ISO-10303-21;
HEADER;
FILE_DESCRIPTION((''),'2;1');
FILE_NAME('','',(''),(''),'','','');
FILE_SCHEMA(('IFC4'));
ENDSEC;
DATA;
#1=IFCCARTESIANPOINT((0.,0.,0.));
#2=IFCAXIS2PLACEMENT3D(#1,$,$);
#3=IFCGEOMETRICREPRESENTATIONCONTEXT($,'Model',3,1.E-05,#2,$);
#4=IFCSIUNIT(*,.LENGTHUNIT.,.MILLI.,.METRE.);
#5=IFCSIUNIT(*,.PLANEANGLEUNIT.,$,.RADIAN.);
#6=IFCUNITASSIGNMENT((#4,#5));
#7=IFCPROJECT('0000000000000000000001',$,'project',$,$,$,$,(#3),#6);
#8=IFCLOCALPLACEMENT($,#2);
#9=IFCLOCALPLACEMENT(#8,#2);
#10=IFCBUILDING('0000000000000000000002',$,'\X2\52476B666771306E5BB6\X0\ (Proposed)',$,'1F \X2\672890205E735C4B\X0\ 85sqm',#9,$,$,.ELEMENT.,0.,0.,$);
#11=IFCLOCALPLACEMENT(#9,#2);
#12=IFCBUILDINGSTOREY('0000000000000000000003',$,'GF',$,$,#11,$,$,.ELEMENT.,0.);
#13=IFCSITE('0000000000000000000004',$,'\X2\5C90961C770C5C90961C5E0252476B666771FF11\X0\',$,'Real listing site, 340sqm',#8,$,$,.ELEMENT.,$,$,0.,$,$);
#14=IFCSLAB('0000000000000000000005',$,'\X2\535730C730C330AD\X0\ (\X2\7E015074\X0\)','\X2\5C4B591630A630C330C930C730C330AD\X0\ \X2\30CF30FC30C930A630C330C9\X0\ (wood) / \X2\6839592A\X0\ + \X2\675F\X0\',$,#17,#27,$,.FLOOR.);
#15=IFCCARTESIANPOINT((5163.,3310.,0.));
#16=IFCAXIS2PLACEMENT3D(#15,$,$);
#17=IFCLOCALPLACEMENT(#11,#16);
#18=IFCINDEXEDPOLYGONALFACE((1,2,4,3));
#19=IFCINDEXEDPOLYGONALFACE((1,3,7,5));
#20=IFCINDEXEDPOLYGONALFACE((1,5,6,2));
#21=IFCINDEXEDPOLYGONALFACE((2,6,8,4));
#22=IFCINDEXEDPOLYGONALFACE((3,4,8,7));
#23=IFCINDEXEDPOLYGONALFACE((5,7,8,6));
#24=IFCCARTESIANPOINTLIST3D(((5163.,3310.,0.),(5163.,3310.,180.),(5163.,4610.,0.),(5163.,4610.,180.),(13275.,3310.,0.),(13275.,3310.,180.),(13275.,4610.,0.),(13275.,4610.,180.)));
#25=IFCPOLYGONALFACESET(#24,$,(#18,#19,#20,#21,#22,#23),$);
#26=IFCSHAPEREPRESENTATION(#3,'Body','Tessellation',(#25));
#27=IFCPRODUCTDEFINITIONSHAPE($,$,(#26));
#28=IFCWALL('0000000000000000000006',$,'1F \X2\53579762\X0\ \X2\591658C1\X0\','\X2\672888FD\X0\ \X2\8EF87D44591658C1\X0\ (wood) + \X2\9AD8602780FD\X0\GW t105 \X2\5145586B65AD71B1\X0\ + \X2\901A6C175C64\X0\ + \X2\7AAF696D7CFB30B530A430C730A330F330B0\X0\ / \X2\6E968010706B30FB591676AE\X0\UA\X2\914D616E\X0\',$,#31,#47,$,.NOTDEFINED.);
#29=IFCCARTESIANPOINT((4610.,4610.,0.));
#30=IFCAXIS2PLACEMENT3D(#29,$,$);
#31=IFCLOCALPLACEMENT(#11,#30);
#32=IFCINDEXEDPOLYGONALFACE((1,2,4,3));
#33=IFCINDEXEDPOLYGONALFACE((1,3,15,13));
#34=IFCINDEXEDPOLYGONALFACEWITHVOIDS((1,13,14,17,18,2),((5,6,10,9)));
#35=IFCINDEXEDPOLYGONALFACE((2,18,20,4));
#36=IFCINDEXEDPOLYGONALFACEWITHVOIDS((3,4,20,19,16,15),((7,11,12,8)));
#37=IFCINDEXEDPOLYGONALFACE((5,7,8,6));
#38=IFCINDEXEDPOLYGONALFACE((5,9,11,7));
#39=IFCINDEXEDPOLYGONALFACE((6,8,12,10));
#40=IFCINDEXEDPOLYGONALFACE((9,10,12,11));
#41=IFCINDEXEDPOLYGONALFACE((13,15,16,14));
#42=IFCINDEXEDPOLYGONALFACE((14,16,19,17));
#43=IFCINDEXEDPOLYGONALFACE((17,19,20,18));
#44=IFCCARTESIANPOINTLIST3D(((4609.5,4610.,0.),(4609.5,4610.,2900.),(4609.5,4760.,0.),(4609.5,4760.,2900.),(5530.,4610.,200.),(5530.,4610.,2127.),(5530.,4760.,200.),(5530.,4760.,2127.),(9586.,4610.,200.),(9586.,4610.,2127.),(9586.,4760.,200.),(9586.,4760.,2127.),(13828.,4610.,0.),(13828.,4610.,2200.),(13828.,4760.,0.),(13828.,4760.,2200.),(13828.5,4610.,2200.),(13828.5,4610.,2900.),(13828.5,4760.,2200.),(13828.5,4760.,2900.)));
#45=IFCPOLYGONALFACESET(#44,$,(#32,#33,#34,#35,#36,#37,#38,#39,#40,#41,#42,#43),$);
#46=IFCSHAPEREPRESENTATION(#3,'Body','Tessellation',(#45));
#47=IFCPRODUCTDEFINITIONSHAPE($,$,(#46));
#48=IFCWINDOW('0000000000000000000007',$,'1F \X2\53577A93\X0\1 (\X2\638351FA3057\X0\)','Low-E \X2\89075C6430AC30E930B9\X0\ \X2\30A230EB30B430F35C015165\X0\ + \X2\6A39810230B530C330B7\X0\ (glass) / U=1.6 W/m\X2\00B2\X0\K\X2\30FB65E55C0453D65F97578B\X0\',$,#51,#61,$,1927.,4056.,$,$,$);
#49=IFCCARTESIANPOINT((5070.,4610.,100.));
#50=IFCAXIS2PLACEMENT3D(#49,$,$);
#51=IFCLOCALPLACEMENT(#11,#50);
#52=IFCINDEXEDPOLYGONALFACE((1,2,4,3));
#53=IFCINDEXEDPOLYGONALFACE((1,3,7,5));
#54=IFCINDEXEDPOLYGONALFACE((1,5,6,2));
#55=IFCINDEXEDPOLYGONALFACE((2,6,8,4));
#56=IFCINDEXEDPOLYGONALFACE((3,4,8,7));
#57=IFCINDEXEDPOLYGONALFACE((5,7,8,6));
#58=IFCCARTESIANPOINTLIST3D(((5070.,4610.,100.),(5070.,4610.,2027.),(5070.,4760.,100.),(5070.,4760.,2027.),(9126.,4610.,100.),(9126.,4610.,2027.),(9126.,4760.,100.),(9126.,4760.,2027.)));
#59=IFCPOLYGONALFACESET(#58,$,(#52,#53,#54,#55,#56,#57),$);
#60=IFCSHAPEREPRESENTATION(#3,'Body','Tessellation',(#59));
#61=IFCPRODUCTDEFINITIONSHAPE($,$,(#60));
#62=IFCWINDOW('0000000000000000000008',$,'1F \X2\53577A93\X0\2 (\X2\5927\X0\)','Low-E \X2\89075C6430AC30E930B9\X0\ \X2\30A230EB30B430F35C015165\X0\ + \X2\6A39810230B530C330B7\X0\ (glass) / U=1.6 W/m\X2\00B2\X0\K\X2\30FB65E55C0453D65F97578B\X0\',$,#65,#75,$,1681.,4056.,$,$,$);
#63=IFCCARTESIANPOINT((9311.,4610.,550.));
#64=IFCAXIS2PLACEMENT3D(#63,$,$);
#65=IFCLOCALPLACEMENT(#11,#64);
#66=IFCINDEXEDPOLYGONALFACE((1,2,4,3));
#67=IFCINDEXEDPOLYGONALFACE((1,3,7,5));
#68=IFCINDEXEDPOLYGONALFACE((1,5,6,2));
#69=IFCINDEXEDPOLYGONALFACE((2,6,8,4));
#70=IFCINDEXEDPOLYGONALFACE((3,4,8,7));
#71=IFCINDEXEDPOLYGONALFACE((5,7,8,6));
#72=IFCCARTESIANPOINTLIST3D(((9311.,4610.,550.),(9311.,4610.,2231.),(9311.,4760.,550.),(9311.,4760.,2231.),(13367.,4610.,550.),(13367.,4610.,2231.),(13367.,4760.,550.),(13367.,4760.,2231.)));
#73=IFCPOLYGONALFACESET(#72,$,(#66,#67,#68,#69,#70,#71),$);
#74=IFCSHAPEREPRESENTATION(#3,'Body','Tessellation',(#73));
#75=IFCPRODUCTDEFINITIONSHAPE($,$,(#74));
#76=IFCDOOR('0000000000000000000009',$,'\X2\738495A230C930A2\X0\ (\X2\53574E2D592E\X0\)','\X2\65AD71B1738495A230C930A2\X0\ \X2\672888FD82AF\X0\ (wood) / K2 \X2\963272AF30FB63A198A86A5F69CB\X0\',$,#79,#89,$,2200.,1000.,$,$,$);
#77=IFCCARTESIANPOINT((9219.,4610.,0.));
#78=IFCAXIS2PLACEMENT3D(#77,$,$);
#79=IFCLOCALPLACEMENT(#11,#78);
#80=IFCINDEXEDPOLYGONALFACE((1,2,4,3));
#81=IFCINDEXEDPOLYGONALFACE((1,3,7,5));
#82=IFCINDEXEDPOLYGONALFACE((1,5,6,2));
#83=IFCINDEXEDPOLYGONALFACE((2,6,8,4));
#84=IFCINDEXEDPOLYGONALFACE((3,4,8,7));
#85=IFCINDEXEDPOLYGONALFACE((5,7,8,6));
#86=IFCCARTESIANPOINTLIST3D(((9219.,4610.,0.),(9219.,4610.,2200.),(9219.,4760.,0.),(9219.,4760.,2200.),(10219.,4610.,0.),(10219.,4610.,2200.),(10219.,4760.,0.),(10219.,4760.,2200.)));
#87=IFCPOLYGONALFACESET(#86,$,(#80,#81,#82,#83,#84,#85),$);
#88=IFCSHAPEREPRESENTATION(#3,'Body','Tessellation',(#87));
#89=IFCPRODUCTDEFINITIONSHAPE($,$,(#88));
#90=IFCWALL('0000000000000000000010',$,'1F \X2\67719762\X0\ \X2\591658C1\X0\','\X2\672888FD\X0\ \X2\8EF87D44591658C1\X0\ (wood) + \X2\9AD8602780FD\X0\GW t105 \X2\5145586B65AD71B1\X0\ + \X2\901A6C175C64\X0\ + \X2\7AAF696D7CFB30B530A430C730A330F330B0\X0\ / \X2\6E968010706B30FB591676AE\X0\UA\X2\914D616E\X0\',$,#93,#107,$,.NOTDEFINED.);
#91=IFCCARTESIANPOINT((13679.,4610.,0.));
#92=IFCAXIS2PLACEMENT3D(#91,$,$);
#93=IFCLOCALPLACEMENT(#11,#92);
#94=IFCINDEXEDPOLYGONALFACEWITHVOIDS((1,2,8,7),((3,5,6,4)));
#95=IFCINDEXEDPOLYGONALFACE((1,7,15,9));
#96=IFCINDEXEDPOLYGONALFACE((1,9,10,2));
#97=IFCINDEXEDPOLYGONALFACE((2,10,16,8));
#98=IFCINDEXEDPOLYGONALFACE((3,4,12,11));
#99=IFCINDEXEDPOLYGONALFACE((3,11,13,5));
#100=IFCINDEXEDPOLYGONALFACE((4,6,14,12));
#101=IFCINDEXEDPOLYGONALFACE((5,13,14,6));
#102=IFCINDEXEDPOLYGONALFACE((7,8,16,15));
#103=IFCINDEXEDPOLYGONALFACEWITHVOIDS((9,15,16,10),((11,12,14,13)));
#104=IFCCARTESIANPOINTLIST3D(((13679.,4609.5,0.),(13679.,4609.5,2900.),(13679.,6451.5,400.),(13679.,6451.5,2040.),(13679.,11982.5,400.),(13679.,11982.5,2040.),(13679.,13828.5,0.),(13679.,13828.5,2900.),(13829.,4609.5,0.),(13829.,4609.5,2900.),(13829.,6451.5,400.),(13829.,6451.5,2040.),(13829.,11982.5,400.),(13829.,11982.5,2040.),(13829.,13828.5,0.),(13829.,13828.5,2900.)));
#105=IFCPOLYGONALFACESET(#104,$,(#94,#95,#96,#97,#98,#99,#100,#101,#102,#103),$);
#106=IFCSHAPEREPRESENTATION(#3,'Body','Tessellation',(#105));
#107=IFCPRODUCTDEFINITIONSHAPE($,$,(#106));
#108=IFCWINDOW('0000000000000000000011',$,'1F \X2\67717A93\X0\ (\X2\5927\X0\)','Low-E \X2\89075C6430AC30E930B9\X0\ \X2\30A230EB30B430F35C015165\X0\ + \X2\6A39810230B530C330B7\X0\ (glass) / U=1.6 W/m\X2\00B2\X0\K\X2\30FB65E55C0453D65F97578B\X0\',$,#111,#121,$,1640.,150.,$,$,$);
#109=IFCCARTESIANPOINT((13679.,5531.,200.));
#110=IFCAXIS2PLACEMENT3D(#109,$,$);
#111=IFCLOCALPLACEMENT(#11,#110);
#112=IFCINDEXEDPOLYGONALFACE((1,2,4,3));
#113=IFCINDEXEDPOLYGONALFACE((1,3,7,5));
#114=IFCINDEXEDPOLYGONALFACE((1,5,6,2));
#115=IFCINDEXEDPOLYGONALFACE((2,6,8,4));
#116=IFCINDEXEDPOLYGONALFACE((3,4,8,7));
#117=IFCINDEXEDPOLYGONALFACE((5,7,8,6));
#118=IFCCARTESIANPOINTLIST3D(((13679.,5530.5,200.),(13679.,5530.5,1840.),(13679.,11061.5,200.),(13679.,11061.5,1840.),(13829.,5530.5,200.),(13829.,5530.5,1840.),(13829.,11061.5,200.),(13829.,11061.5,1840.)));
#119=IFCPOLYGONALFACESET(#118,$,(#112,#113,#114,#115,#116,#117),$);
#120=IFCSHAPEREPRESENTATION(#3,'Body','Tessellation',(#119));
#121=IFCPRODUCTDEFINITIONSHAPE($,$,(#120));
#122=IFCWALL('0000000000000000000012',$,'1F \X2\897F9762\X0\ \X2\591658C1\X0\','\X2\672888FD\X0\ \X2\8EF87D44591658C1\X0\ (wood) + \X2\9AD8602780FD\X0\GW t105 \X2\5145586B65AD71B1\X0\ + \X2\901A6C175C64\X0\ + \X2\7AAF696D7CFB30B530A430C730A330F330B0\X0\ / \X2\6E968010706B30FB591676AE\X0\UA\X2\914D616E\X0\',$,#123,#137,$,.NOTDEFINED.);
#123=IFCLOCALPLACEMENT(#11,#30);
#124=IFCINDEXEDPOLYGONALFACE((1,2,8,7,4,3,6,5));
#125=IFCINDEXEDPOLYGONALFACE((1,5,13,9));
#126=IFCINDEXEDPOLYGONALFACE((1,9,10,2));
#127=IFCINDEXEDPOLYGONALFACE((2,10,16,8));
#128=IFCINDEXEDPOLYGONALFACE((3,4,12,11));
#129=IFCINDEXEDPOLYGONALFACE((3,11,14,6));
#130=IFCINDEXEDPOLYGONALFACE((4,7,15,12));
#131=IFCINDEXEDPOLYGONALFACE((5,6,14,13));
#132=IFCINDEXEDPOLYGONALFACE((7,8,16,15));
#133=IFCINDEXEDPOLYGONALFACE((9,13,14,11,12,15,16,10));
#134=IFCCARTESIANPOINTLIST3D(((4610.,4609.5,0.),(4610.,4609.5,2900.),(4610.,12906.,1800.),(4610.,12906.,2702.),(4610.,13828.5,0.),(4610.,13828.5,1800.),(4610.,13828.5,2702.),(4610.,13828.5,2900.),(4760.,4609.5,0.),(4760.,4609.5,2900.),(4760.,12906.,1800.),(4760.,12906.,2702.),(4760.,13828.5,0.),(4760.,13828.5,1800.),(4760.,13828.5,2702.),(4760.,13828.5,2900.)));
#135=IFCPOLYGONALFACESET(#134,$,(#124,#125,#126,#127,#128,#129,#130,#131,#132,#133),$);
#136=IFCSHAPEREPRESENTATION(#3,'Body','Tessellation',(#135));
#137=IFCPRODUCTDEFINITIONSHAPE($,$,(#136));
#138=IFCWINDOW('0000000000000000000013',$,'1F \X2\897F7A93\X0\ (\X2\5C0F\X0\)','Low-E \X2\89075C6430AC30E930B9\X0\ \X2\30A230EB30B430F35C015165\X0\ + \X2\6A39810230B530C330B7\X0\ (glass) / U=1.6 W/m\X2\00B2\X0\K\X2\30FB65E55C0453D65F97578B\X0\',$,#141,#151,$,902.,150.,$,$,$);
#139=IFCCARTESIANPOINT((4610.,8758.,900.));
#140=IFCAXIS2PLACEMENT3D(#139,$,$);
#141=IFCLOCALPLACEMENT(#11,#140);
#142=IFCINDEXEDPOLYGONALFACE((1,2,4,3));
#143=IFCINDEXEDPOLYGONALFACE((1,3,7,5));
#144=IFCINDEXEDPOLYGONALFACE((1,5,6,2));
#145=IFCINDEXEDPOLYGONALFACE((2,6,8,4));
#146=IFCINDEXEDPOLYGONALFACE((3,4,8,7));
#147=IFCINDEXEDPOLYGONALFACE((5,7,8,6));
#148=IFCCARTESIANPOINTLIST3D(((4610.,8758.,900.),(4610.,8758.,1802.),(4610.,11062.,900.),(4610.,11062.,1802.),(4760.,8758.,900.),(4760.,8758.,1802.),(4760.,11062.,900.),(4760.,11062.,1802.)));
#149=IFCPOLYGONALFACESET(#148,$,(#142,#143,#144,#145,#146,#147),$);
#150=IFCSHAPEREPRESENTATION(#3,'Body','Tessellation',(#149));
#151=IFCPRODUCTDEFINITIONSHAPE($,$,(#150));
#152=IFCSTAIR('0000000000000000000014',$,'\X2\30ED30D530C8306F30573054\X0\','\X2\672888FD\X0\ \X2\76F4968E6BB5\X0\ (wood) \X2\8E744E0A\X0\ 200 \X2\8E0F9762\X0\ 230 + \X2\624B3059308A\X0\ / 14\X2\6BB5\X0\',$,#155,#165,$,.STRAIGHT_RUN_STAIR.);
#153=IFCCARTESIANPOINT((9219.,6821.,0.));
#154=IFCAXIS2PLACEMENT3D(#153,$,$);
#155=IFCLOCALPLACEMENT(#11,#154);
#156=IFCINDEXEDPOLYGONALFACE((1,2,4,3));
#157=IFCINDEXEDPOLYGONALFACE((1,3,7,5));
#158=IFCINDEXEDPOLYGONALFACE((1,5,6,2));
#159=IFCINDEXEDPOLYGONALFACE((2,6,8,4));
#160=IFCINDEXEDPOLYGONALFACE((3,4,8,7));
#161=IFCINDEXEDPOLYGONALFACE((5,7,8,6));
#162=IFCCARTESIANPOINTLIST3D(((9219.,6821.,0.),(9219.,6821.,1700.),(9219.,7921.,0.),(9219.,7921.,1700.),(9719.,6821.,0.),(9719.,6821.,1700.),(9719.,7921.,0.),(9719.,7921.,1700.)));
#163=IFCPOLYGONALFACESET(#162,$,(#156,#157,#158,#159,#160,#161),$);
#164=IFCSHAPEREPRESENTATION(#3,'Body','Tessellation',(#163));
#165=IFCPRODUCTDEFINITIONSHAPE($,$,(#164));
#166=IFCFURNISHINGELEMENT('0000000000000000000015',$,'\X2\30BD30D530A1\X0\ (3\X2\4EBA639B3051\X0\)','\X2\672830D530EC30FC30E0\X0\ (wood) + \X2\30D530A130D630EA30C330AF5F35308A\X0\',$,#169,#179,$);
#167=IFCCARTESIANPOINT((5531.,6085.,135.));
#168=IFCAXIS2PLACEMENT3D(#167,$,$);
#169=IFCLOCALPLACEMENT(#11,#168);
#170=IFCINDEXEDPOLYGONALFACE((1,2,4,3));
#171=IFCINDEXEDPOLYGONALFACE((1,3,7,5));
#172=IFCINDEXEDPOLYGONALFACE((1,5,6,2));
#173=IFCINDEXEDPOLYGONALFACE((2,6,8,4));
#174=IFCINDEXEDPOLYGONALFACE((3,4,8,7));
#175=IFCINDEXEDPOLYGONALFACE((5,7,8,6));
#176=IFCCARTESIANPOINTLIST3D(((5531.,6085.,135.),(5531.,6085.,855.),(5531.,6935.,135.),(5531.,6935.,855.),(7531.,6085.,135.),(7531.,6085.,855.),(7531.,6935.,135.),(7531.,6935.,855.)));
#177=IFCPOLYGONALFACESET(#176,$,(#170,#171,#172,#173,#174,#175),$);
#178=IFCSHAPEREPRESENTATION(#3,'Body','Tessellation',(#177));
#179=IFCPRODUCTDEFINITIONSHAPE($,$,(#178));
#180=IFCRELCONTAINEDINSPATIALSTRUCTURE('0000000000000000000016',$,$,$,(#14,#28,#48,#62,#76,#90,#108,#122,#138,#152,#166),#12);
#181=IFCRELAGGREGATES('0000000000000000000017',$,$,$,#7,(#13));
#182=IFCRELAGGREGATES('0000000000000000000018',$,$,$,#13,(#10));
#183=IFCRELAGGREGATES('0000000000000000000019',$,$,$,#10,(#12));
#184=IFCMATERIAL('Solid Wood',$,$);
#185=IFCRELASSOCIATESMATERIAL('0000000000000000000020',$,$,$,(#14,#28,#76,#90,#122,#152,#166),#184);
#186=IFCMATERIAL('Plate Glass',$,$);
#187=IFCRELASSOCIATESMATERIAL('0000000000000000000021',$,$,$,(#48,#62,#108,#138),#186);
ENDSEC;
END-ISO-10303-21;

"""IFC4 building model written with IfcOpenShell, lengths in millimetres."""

from ifc_helpers import new_model, si_unit, frame, frame_2d, origin, place, context, project, spatial, rectangle, extrude, material, element, fill, save


model = new_model("IFC4")

# Units and contexts
model_context = context("Model", 3, precision=1e-05, world=origin())
ifc_project = project(units=[si_unit("LENGTHUNIT", "METRE", prefix="MILLI"), si_unit("PLANEANGLEUNIT", "RADIAN")], contexts=[model_context])

# Site, building, storey
site_placement = place(None, origin())
site = spatial("IfcSite", under=ifc_project, at=site_placement, Name="岐阜県岐阜市則武東１", ObjectType="Real listing site, 340sqm", CompositionType="ELEMENT", RefElevation=0.0)
building_placement = place(site_placement, origin())
building = spatial("IfcBuilding", under=site, at=building_placement, Name="則武東の家 (Proposed)", ObjectType="1F 木造平屋 85sqm", CompositionType="ELEMENT", ElevationOfRefHeight=0.0, ElevationOfTerrain=0.0)
storey_placement = place(building_placement, origin())
storey = spatial("IfcBuildingStorey", under=building, at=storey_placement, Name="GF", CompositionType="ELEMENT", Elevation=0.0)

# Slab
ifc_material_1 = material(Name="Solid Wood")
slab_1_placement = place(storey_placement, frame((5163.0, 3310.0, 0.0)))
element("IfcSlab", 1, at=slab_1_placement, inside=storey, material=ifc_material_1, Name="南デッキ (縁側)", Description="屋外ウッドデッキ ハードウッド (wood) / 根太 + 束", PredefinedType="FLOOR", context=model_context, shape_type="SweptSolid", body=[
    extrude(rectangle(XDim=8112.0, YDim=1300.0, at=frame_2d((4056.0, 650.0))), frame((5163.0, 3310.0, 0.0)), (0.0, 0.0, 1.0), 180.0),
])

# Wall, openings, windows, door
wall_1_placement = place(storey_placement, frame((4610.0, 4610.0, 0.0)))
wall_1 = element("IfcWall", 2, at=wall_1_placement, inside=storey, material=ifc_material_1, Name="1F 南面 外壁", Description="木製 軸組外壁 (wood) + 高性能GW t105 充填断熱 + 通気層 + 窯業系サイディング / 準耐火・外皮UA配慮", PredefinedType="NOTDEFINED", context=model_context, shape_type="SweptSolid", body=[
    extrude(rectangle(XDim=9219.0, YDim=150.0, at=frame_2d((4609.0, 75.0))), frame((4610.0, 4610.0, 0.0)), (0.0, 0.0, 1.0), 2900.0),
])
opening_1_placement = place(storey_placement, frame((5070.0, 4610.0, 100.0)))
opening_1 = element("IfcOpeningElement", 3, at=opening_1_placement, cuts=wall_1, PredefinedType="NOTDEFINED", context=model_context, shape_type="SweptSolid", body=[
    extrude(rectangle(XDim=4056.0, YDim=150.0, at=frame_2d((2028.0, 75.0))), frame((5070.0, 4610.0, 100.0)), (0.0, 0.0, 1.0), 1927.0),
])
opening_2_placement = place(storey_placement, frame((9311.0, 4610.0, 550.0)))
opening_2 = element("IfcOpeningElement", 4, at=opening_2_placement, cuts=wall_1, PredefinedType="NOTDEFINED", context=model_context, shape_type="SweptSolid", body=[
    extrude(rectangle(XDim=4056.0, YDim=150.0, at=frame_2d((2028.0, 75.0))), frame((9311.0, 4610.0, 550.0)), (0.0, 0.0, 1.0), 1681.0),
])
opening_3_placement = place(storey_placement, frame((9219.0, 4610.0, 0.0)))
opening_3 = element("IfcOpeningElement", 5, at=opening_3_placement, cuts=wall_1, PredefinedType="NOTDEFINED", context=model_context, shape_type="SweptSolid", body=[
    extrude(rectangle(XDim=1000.0, YDim=150.0, at=frame_2d((500.0, 75.0))), frame((9219.0, 4610.0, 0.0)), (0.0, 0.0, 1.0), 2200.0),
])
ifc_material_2 = material(Name="Plate Glass")
window_1_placement = place(storey_placement, frame((5070.0, 4610.0, 100.0)))
window_1 = element("IfcWindow", 6, at=window_1_placement, inside=storey, material=ifc_material_2, Name="1F 南窓1 (掃出し)", Description="Low-E 複層ガラス アルゴン封入 + 樹脂サッシ (glass) / U=1.6 W/m²K・日射取得型", OverallHeight=1927.0, OverallWidth=4056.0, context=model_context, shape_type="SweptSolid", body=[
    extrude(rectangle(XDim=4056.0, YDim=150.0, at=frame_2d((2028.0, 75.0))), frame((5070.0, 4610.0, 100.0)), (0.0, 0.0, 1.0), 1927.0),
])
fill(opening_1, window_1)
window_2_placement = place(storey_placement, frame((9311.0, 4610.0, 550.0)))
window_2 = element("IfcWindow", 7, at=window_2_placement, inside=storey, material=ifc_material_2, Name="1F 南窓2 (大)", Description="Low-E 複層ガラス アルゴン封入 + 樹脂サッシ (glass) / U=1.6 W/m²K・日射取得型", OverallHeight=1681.0, OverallWidth=4056.0, context=model_context, shape_type="SweptSolid", body=[
    extrude(rectangle(XDim=4056.0, YDim=150.0, at=frame_2d((2028.0, 75.0))), frame((9311.0, 4610.0, 550.0)), (0.0, 0.0, 1.0), 1681.0),
])
fill(opening_2, window_2)
door_placement = place(storey_placement, frame((9219.0, 4610.0, 0.0)))
door = element("IfcDoor", 8, at=door_placement, inside=storey, material=ifc_material_1, Name="玄関ドア (南中央)", Description="断熱玄関ドア 木製芯 (wood) / K2 防犯・採風機構", OverallHeight=2200.0, OverallWidth=1000.0, context=model_context, shape_type="SweptSolid", body=[
    extrude(rectangle(XDim=1000.0, YDim=150.0, at=frame_2d((500.0, 75.0))), frame((9219.0, 4610.0, 0.0)), (0.0, 0.0, 1.0), 2200.0),
])
fill(opening_3, door)

# Walls, openings, windows
wall_2_placement = place(storey_placement, frame((13679.0, 4610.0, 0.0)))
wall_2 = element("IfcWall", 9, at=wall_2_placement, inside=storey, material=ifc_material_1, Name="1F 東面 外壁", Description="木製 軸組外壁 (wood) + 高性能GW t105 充填断熱 + 通気層 + 窯業系サイディング / 準耐火・外皮UA配慮", PredefinedType="NOTDEFINED", context=model_context, shape_type="SweptSolid", body=[
    extrude(rectangle(XDim=150.0, YDim=9219.0, at=frame_2d((75.0, 4609.0))), frame((13679.0, 4610.0, 0.0)), (0.0, 0.0, 1.0), 2900.0),
])
opening_4_placement = place(storey_placement, frame((13679.0, 5531.0, 200.0)))
opening_4 = element("IfcOpeningElement", 10, at=opening_4_placement, cuts=wall_2, PredefinedType="NOTDEFINED", context=model_context, shape_type="SweptSolid", body=[
    extrude(rectangle(XDim=150.0, YDim=5531.0, at=frame_2d((75.0, 2765.0))), frame((13679.0, 5531.0, 200.0)), (0.0, 0.0, 1.0), 1640.0),
])
window_3_placement = place(storey_placement, frame((13679.0, 5531.0, 200.0)))
window_3 = element("IfcWindow", 11, at=window_3_placement, inside=storey, material=ifc_material_2, Name="1F 東窓 (大)", Description="Low-E 複層ガラス アルゴン封入 + 樹脂サッシ (glass) / U=1.6 W/m²K・日射取得型", OverallHeight=1640.0, OverallWidth=150.0, context=model_context, shape_type="SweptSolid", body=[
    extrude(rectangle(XDim=150.0, YDim=5531.0, at=frame_2d((75.0, 2765.0))), frame((13679.0, 5531.0, 200.0)), (0.0, 0.0, 1.0), 1640.0),
])
fill(opening_4, window_3)
wall_3_placement = place(storey_placement, frame((4610.0, 4610.0, 0.0)))
wall_3 = element("IfcWall", 12, at=wall_3_placement, inside=storey, material=ifc_material_1, Name="1F 西面 外壁", Description="木製 軸組外壁 (wood) + 高性能GW t105 充填断熱 + 通気層 + 窯業系サイディング / 準耐火・外皮UA配慮", PredefinedType="NOTDEFINED", context=model_context, shape_type="SweptSolid", body=[
    extrude(rectangle(XDim=150.0, YDim=9219.0, at=frame_2d((75.0, 4609.0))), frame((4610.0, 4610.0, 0.0)), (0.0, 0.0, 1.0), 2900.0),
])
opening_5_placement = place(storey_placement, frame((4610.0, 8758.0, 900.0)))
opening_5 = element("IfcOpeningElement", 13, at=opening_5_placement, cuts=wall_3, PredefinedType="NOTDEFINED", context=model_context, shape_type="SweptSolid", body=[
    extrude(rectangle(XDim=150.0, YDim=2304.0, at=frame_2d((75.0, 1152.0))), frame((4610.0, 8758.0, 900.0)), (0.0, 0.0, 1.0), 902.0),
])
window_4_placement = place(storey_placement, frame((4610.0, 8758.0, 900.0)))
window_4 = element("IfcWindow", 14, at=window_4_placement, inside=storey, material=ifc_material_2, Name="1F 西窓 (小)", Description="Low-E 複層ガラス アルゴン封入 + 樹脂サッシ (glass) / U=1.6 W/m²K・日射取得型", OverallHeight=902.0, OverallWidth=150.0, context=model_context, shape_type="SweptSolid", body=[
    extrude(rectangle(XDim=150.0, YDim=2304.0, at=frame_2d((75.0, 1152.0))), frame((4610.0, 8758.0, 900.0)), (0.0, 0.0, 1.0), 902.0),
])
fill(opening_5, window_4)

# Stair
stair_placement = place(storey_placement, frame((9219.0, 6821.0, 0.0)))
element("IfcStair", 15, at=stair_placement, inside=storey, material=ifc_material_1, Name="ロフトはしご", Description="木製 直階段 (wood) 蹴上 200 踏面 230 + 手すり / 14段", PredefinedType="STRAIGHT_RUN_STAIR", context=model_context, shape_type="SweptSolid", body=[
    extrude(rectangle(XDim=500.0, YDim=1100.0, at=frame_2d((250.0, 550.0))), frame((9219.0, 6821.0, 0.0)), (0.0, 0.0, 1.0), 1700.0),
])

# Furnishing element
furnishing_1_placement = place(storey_placement, frame((5531.0, 6085.0, 135.0)))
element("IfcFurnishingElement", 16, at=furnishing_1_placement, inside=storey, material=ifc_material_1, Name="ソファ (3人掛け)", Description="木フレーム (wood) + ファブリック張り", context=model_context, shape_type="SweptSolid", body=[
    extrude(rectangle(XDim=2000.0, YDim=850.0, at=frame_2d((1000.0, 425.0))), frame((5531.0, 6085.0, 135.0)), (0.0, 0.0, 1.0), 720.0),
])

save(model, "model.ifc")
